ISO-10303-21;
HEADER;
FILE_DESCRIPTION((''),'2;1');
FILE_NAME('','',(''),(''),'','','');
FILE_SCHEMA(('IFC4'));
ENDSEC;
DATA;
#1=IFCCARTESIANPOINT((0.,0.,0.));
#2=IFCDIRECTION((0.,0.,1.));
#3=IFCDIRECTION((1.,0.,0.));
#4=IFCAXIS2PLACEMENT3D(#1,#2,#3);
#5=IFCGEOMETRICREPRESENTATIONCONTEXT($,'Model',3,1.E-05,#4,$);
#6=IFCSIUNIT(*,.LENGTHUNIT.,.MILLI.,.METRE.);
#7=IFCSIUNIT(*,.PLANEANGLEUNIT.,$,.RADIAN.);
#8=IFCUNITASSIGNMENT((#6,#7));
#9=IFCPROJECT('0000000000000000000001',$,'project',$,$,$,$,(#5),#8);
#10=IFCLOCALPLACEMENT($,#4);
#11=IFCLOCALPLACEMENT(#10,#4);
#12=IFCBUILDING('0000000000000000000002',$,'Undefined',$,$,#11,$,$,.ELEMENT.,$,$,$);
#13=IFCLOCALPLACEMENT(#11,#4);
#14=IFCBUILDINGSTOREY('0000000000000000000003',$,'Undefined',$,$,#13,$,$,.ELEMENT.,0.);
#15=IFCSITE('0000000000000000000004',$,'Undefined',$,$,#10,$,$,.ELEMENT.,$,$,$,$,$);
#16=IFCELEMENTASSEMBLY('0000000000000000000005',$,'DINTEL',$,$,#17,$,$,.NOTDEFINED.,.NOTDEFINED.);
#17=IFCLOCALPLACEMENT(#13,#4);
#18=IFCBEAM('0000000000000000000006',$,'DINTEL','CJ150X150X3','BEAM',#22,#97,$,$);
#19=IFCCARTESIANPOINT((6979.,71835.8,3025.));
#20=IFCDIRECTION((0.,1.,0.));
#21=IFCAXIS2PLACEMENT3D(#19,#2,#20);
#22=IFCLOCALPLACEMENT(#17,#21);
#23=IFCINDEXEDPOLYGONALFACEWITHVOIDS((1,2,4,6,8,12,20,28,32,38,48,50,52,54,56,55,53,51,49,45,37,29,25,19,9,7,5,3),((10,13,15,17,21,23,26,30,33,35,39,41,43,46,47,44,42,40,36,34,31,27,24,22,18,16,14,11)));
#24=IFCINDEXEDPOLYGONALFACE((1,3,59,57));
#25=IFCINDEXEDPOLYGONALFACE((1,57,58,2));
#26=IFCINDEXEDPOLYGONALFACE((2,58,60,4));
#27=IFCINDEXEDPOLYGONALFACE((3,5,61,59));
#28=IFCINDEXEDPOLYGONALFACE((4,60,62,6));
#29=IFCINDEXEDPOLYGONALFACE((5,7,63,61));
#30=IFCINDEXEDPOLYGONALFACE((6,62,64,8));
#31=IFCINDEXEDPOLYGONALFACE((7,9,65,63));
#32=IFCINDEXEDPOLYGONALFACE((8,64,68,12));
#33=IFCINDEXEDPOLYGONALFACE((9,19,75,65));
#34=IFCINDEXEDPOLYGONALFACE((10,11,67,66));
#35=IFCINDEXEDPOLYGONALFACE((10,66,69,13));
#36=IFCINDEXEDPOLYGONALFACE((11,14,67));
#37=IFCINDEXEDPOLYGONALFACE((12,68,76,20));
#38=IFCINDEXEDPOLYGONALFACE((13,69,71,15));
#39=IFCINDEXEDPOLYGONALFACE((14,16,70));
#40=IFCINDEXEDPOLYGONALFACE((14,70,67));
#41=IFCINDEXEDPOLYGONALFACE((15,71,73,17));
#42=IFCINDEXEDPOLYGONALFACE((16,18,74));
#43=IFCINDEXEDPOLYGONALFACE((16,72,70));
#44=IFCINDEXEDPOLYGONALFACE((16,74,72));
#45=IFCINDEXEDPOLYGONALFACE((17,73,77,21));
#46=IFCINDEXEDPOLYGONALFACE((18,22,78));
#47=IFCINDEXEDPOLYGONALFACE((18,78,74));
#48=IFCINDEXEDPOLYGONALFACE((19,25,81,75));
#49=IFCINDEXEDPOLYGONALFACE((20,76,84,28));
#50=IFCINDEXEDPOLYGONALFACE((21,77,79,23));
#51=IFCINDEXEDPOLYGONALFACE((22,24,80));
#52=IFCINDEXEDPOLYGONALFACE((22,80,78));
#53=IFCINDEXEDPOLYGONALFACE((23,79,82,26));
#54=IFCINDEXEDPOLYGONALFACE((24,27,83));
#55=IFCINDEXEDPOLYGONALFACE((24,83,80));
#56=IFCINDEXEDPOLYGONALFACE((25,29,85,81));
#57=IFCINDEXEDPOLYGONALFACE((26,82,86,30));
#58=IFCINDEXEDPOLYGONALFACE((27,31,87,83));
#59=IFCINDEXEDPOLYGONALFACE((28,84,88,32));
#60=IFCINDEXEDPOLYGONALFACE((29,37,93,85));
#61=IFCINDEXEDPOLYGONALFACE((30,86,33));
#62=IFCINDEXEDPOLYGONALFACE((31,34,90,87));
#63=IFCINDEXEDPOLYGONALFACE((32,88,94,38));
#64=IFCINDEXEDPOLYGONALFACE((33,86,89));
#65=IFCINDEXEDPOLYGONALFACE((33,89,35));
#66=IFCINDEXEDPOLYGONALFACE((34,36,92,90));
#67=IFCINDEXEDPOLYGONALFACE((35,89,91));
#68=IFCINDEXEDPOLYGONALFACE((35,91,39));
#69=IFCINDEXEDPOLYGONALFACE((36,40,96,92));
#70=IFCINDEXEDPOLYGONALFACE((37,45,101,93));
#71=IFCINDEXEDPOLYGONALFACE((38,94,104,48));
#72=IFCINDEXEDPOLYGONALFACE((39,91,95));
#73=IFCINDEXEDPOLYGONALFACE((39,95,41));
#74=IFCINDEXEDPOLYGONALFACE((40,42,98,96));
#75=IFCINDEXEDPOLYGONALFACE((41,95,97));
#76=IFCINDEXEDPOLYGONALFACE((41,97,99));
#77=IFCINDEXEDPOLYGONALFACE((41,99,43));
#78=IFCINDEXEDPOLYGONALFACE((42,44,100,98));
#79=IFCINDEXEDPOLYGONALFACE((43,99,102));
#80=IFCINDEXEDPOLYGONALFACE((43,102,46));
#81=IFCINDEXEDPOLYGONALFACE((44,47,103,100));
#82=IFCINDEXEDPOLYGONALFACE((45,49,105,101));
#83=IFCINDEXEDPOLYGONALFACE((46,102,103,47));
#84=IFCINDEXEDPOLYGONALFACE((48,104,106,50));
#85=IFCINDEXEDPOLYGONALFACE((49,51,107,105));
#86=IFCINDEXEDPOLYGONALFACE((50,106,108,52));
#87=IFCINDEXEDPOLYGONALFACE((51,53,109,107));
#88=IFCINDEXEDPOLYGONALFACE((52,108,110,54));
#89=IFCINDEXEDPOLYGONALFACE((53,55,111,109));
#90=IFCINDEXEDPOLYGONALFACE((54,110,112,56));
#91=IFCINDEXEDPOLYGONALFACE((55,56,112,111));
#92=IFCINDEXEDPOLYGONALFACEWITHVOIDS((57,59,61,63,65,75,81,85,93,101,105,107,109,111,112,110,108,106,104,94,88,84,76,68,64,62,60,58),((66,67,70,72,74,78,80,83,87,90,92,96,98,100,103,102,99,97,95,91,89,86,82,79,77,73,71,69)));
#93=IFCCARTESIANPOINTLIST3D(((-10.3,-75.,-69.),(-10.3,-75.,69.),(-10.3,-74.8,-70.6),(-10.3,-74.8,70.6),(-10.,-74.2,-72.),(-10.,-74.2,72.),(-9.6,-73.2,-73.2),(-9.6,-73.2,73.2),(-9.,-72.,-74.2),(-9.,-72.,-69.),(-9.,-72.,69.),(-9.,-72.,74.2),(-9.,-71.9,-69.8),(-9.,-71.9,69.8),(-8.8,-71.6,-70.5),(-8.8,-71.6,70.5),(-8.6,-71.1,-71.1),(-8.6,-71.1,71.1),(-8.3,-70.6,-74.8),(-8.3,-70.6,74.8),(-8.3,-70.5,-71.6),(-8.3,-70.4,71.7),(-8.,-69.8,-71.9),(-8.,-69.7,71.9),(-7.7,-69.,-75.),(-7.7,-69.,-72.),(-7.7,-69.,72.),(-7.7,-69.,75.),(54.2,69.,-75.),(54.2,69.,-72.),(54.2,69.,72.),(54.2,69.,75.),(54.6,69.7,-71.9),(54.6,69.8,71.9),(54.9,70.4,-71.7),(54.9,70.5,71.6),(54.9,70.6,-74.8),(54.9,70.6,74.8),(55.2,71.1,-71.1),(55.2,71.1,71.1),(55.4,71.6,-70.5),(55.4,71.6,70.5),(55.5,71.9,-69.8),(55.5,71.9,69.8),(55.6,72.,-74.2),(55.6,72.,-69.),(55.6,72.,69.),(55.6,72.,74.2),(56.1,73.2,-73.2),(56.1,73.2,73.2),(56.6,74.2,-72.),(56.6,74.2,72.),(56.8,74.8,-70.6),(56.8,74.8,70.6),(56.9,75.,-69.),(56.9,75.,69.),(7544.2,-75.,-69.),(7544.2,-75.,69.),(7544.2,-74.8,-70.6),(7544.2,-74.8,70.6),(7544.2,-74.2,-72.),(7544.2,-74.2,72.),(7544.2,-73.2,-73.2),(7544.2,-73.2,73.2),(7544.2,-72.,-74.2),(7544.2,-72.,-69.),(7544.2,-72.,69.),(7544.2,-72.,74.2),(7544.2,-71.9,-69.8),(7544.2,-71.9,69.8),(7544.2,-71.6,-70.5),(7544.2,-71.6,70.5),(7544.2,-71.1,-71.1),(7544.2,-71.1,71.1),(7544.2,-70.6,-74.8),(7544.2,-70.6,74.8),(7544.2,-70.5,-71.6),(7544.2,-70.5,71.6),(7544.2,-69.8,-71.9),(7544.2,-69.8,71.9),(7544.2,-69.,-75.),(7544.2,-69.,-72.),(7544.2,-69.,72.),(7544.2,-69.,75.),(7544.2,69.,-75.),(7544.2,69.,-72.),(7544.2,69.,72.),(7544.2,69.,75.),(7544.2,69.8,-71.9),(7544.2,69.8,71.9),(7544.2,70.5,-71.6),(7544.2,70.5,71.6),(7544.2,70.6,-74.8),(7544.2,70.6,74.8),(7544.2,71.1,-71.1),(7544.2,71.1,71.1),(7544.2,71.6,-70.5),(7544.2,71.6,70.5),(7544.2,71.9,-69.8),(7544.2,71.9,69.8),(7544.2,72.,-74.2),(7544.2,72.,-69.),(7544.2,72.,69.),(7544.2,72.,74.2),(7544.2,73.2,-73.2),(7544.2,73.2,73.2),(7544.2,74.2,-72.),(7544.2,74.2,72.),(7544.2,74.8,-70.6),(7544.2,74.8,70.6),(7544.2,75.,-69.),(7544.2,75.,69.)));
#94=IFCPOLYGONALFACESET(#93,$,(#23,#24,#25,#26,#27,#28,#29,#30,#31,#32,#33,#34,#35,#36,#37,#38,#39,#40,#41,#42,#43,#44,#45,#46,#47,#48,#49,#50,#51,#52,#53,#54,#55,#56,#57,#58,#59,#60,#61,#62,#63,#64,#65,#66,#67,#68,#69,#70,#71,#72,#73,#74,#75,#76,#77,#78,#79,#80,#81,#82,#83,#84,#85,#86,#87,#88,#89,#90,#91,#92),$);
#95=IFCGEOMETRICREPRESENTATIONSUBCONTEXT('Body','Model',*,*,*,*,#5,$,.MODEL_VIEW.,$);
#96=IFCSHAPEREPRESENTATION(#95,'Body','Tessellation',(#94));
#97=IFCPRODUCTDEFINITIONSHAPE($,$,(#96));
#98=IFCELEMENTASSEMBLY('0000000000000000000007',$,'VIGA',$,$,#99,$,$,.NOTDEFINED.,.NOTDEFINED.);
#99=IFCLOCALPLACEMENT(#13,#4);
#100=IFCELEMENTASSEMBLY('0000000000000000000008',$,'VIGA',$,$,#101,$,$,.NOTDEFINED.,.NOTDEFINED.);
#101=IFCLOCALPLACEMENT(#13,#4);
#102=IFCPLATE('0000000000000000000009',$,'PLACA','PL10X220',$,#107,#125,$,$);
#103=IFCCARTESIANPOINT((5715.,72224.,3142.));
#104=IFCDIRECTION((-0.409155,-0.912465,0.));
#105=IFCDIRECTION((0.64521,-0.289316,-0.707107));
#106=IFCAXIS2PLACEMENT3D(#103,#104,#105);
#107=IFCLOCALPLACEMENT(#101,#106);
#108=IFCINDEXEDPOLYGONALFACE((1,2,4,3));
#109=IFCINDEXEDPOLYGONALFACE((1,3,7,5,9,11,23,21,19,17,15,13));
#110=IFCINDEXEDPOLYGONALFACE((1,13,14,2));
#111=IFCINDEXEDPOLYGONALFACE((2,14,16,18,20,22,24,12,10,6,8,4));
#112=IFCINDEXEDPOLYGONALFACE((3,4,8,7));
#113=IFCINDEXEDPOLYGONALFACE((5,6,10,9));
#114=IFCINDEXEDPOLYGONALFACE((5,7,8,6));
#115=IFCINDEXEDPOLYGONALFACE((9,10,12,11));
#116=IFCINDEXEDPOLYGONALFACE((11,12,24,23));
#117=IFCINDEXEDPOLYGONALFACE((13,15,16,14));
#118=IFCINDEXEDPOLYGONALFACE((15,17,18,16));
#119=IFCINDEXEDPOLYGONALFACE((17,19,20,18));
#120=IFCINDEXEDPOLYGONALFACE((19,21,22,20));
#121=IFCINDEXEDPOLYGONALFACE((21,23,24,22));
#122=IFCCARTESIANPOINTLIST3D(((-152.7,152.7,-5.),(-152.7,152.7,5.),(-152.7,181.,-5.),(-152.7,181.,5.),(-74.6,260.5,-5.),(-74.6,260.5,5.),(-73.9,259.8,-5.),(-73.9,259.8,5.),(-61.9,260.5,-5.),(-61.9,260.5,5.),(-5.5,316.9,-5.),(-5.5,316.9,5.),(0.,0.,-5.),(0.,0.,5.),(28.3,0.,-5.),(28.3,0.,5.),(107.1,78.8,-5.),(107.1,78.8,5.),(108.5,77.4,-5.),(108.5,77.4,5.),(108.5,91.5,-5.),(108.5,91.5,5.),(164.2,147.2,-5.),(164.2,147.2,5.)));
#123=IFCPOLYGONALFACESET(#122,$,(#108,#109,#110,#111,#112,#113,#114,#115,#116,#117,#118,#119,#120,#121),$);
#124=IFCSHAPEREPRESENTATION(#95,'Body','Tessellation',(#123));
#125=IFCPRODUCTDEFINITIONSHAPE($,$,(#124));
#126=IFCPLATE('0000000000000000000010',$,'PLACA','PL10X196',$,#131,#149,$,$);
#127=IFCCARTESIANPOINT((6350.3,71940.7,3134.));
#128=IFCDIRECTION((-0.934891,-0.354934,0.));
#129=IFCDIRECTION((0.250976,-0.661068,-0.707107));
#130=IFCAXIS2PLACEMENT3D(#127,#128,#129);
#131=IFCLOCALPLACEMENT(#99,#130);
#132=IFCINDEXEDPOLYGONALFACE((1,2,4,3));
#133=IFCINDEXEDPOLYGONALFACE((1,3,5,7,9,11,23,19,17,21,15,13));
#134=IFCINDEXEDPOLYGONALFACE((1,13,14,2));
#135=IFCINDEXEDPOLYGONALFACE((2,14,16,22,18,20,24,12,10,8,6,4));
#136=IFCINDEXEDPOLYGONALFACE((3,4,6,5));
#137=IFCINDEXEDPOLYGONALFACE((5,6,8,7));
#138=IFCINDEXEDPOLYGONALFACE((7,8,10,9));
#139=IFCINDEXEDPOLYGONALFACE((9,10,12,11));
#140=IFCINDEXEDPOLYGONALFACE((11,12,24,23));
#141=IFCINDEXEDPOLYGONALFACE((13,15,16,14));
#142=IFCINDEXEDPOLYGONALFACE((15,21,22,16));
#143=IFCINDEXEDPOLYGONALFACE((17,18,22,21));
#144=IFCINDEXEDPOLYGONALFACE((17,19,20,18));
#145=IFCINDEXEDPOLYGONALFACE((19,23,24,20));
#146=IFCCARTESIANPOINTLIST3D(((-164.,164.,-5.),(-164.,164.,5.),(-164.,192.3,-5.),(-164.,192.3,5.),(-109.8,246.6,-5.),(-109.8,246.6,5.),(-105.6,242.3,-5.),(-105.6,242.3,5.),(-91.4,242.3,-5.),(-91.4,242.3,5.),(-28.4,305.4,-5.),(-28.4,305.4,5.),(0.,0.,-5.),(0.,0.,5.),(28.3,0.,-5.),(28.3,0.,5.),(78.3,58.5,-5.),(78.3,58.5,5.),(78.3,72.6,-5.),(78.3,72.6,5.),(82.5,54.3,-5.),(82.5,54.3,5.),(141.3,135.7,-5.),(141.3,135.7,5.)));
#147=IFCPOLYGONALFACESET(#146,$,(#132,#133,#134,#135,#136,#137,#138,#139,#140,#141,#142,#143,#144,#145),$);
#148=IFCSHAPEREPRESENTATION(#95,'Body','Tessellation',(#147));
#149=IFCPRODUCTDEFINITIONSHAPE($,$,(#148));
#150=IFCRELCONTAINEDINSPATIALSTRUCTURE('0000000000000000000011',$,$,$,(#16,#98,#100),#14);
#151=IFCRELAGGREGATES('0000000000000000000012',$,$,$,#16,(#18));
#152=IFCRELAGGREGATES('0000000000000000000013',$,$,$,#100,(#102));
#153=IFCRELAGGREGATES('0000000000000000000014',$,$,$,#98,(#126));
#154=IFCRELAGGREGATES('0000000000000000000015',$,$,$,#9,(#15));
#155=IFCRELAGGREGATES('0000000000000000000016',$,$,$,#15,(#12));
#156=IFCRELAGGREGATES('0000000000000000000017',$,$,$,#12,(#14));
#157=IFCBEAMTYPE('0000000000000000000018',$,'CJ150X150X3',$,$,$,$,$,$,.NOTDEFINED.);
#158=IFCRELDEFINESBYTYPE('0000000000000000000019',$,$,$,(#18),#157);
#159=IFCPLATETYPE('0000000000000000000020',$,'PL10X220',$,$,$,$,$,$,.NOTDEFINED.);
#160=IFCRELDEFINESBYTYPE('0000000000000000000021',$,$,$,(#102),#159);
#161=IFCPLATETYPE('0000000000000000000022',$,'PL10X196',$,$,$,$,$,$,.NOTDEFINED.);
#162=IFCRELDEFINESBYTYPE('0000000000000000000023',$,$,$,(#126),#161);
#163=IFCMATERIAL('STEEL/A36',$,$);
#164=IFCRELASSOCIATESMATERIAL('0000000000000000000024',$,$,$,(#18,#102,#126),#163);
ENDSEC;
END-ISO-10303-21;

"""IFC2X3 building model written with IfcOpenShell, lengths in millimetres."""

from ifc_helpers import new_model, si_unit, frame, origin_with_axes, origin_2d_with_axis, place, context, subcontext, project, spatial, polyline, hollow_rectangle, outline, extrude, clip, halfspace, material, type_object, element, aggregate, save


model = new_model("IFC2X3")

# Units and contexts
model_context = context("Model", 3, precision=1e-05, world=origin_with_axes())
body_context = subcontext(model_context, "Body", "Model", "MODEL_VIEW")
ifc_project = project(units=[si_unit("LENGTHUNIT", "METRE", prefix="MILLI"), si_unit("PLANEANGLEUNIT", "RADIAN")], contexts=[model_context])

# Site, building, storey
site_placement = place(None, origin_with_axes())
site = spatial("IfcSite", under=ifc_project, at=site_placement, Name="Undefined", CompositionType="ELEMENT")
building_placement = place(site_placement, origin_with_axes())
building = spatial("IfcBuilding", under=site, at=building_placement, Name="Undefined", CompositionType="ELEMENT")
storey_placement = place(building_placement, origin_with_axes())
storey = spatial("IfcBuildingStorey", under=building, at=storey_placement, Name="Undefined", CompositionType="ELEMENT", Elevation=0.0)

# Shared definitions
ifc_material_1 = material(Name="STEEL/A36")

# Element assembly, beam
assembly_1_placement = place(storey_placement, origin_with_axes())
assembly_1 = element("IfcElementAssembly", 1, at=assembly_1_placement, inside=storey, Name="DINTEL", AssemblyPlace="NOTDEFINED", PredefinedType="NOTDEFINED")
beam_type_1 = type_object("IfcBeamType", Name="CJ150X150X3", PredefinedType="NOTDEFINED")
beam_1_placement = place(assembly_1_placement, frame((6979.0, 71835.8, 3025.0), z_axis=(0.0, 0.0, 1.0), x_axis=(0.0, 1.0, 0.0)))
beam_1 = element("IfcBeam", 2, at=beam_1_placement, type_object=beam_type_1, material=ifc_material_1, Name="DINTEL", Description="CJ150X150X3", ObjectType="BEAM", context=body_context, shape_type="Clipping", body=[
    clip(extrude(hollow_rectangle(XDim=150.0, YDim=150.0, WallThickness=3.0, InnerFilletRadius=3.0, OuterFilletRadius=6.0, at=origin_2d_with_axis()), frame((7544.2, 0.0, 0.0), z_axis=(-1.0, 0.0, 0.0), x_axis=(0.0, -1.0, 0.0)), (0.0, 0.0, 1.0), 7554.8), halfspace(frame((36.7, 29.9, 375.0), z_axis=(-0.912463, 0.409159, 0.0), x_axis=(0.0, 0.0, 1.0)), False)),
])

aggregate(assembly_1, [beam_1])

# Element assembly
assembly_2_placement = place(storey_placement, origin_with_axes())
assembly_2 = element("IfcElementAssembly", 3, at=assembly_2_placement, inside=storey, Name="VIGA", AssemblyPlace="NOTDEFINED", PredefinedType="NOTDEFINED")

# Element assembly, plate
assembly_3_placement = place(storey_placement, origin_with_axes())
assembly_3 = element("IfcElementAssembly", 4, at=assembly_3_placement, inside=storey, Name="VIGA", AssemblyPlace="NOTDEFINED", PredefinedType="NOTDEFINED")
plate_type_1 = type_object("IfcPlateType", Name="PL10X220", PredefinedType="NOTDEFINED")
plate_1_placement = place(assembly_3_placement, frame((5715.0, 72224.0, 3142.0), z_axis=(-0.409155, -0.912465, 0.0), x_axis=(0.64521, -0.289316, -0.707107)))
plate_1 = element("IfcPlate", 5, at=plate_1_placement, type_object=plate_type_1, material=ifc_material_1, Name="PLACA", Description="PL10X220", context=body_context, shape_type="SweptSolid", body=[
    extrude(outline(polyline([(0.0, 0.0), (28.3, 0.0), (107.1, 78.8), (108.5, 77.4), (108.5, 91.5), (164.2, 147.2), (-5.5, 316.9), (-61.9, 260.5), (-74.6, 260.5), (-73.9, 259.8), (-152.7, 181.0), (-152.7, 152.7), (0.0, 0.0)])), frame((0.0, 0.0, -5.0), z_axis=(0.0, 0.0, 1.0), x_axis=(1.0, 0.0, 0.0)), (0.0, 0.0, 1.0), 10.0),
])
aggregate(assembly_3, [plate_1])

# Plate
plate_type_2 = type_object("IfcPlateType", Name="PL10X196", PredefinedType="NOTDEFINED")
plate_2_placement = place(assembly_2_placement, frame((6350.3, 71940.7, 3134.0), z_axis=(-0.934891, -0.354934, 0.0), x_axis=(0.250976, -0.661068, -0.707107)))
plate_2 = element("IfcPlate", 6, at=plate_2_placement, type_object=plate_type_2, material=ifc_material_1, Name="PLACA", Description="PL10X196", context=body_context, shape_type="SweptSolid", body=[
    extrude(outline(polyline([(0.0, 0.0), (28.3, 0.0), (82.5, 54.3), (78.3, 58.5), (78.3, 72.6), (141.3, 135.7), (-28.4, 305.4), (-91.4, 242.3), (-105.6, 242.3), (-109.8, 246.6), (-164.0, 192.3), (-164.0, 164.0), (0.0, 0.0)])), frame((0.0, 0.0, -5.0), z_axis=(0.0, 0.0, 1.0), x_axis=(1.0, 0.0, 0.0)), (0.0, 0.0, 1.0), 10.0),
])

aggregate(assembly_2, [plate_2])

save(model, "model.ifc")
